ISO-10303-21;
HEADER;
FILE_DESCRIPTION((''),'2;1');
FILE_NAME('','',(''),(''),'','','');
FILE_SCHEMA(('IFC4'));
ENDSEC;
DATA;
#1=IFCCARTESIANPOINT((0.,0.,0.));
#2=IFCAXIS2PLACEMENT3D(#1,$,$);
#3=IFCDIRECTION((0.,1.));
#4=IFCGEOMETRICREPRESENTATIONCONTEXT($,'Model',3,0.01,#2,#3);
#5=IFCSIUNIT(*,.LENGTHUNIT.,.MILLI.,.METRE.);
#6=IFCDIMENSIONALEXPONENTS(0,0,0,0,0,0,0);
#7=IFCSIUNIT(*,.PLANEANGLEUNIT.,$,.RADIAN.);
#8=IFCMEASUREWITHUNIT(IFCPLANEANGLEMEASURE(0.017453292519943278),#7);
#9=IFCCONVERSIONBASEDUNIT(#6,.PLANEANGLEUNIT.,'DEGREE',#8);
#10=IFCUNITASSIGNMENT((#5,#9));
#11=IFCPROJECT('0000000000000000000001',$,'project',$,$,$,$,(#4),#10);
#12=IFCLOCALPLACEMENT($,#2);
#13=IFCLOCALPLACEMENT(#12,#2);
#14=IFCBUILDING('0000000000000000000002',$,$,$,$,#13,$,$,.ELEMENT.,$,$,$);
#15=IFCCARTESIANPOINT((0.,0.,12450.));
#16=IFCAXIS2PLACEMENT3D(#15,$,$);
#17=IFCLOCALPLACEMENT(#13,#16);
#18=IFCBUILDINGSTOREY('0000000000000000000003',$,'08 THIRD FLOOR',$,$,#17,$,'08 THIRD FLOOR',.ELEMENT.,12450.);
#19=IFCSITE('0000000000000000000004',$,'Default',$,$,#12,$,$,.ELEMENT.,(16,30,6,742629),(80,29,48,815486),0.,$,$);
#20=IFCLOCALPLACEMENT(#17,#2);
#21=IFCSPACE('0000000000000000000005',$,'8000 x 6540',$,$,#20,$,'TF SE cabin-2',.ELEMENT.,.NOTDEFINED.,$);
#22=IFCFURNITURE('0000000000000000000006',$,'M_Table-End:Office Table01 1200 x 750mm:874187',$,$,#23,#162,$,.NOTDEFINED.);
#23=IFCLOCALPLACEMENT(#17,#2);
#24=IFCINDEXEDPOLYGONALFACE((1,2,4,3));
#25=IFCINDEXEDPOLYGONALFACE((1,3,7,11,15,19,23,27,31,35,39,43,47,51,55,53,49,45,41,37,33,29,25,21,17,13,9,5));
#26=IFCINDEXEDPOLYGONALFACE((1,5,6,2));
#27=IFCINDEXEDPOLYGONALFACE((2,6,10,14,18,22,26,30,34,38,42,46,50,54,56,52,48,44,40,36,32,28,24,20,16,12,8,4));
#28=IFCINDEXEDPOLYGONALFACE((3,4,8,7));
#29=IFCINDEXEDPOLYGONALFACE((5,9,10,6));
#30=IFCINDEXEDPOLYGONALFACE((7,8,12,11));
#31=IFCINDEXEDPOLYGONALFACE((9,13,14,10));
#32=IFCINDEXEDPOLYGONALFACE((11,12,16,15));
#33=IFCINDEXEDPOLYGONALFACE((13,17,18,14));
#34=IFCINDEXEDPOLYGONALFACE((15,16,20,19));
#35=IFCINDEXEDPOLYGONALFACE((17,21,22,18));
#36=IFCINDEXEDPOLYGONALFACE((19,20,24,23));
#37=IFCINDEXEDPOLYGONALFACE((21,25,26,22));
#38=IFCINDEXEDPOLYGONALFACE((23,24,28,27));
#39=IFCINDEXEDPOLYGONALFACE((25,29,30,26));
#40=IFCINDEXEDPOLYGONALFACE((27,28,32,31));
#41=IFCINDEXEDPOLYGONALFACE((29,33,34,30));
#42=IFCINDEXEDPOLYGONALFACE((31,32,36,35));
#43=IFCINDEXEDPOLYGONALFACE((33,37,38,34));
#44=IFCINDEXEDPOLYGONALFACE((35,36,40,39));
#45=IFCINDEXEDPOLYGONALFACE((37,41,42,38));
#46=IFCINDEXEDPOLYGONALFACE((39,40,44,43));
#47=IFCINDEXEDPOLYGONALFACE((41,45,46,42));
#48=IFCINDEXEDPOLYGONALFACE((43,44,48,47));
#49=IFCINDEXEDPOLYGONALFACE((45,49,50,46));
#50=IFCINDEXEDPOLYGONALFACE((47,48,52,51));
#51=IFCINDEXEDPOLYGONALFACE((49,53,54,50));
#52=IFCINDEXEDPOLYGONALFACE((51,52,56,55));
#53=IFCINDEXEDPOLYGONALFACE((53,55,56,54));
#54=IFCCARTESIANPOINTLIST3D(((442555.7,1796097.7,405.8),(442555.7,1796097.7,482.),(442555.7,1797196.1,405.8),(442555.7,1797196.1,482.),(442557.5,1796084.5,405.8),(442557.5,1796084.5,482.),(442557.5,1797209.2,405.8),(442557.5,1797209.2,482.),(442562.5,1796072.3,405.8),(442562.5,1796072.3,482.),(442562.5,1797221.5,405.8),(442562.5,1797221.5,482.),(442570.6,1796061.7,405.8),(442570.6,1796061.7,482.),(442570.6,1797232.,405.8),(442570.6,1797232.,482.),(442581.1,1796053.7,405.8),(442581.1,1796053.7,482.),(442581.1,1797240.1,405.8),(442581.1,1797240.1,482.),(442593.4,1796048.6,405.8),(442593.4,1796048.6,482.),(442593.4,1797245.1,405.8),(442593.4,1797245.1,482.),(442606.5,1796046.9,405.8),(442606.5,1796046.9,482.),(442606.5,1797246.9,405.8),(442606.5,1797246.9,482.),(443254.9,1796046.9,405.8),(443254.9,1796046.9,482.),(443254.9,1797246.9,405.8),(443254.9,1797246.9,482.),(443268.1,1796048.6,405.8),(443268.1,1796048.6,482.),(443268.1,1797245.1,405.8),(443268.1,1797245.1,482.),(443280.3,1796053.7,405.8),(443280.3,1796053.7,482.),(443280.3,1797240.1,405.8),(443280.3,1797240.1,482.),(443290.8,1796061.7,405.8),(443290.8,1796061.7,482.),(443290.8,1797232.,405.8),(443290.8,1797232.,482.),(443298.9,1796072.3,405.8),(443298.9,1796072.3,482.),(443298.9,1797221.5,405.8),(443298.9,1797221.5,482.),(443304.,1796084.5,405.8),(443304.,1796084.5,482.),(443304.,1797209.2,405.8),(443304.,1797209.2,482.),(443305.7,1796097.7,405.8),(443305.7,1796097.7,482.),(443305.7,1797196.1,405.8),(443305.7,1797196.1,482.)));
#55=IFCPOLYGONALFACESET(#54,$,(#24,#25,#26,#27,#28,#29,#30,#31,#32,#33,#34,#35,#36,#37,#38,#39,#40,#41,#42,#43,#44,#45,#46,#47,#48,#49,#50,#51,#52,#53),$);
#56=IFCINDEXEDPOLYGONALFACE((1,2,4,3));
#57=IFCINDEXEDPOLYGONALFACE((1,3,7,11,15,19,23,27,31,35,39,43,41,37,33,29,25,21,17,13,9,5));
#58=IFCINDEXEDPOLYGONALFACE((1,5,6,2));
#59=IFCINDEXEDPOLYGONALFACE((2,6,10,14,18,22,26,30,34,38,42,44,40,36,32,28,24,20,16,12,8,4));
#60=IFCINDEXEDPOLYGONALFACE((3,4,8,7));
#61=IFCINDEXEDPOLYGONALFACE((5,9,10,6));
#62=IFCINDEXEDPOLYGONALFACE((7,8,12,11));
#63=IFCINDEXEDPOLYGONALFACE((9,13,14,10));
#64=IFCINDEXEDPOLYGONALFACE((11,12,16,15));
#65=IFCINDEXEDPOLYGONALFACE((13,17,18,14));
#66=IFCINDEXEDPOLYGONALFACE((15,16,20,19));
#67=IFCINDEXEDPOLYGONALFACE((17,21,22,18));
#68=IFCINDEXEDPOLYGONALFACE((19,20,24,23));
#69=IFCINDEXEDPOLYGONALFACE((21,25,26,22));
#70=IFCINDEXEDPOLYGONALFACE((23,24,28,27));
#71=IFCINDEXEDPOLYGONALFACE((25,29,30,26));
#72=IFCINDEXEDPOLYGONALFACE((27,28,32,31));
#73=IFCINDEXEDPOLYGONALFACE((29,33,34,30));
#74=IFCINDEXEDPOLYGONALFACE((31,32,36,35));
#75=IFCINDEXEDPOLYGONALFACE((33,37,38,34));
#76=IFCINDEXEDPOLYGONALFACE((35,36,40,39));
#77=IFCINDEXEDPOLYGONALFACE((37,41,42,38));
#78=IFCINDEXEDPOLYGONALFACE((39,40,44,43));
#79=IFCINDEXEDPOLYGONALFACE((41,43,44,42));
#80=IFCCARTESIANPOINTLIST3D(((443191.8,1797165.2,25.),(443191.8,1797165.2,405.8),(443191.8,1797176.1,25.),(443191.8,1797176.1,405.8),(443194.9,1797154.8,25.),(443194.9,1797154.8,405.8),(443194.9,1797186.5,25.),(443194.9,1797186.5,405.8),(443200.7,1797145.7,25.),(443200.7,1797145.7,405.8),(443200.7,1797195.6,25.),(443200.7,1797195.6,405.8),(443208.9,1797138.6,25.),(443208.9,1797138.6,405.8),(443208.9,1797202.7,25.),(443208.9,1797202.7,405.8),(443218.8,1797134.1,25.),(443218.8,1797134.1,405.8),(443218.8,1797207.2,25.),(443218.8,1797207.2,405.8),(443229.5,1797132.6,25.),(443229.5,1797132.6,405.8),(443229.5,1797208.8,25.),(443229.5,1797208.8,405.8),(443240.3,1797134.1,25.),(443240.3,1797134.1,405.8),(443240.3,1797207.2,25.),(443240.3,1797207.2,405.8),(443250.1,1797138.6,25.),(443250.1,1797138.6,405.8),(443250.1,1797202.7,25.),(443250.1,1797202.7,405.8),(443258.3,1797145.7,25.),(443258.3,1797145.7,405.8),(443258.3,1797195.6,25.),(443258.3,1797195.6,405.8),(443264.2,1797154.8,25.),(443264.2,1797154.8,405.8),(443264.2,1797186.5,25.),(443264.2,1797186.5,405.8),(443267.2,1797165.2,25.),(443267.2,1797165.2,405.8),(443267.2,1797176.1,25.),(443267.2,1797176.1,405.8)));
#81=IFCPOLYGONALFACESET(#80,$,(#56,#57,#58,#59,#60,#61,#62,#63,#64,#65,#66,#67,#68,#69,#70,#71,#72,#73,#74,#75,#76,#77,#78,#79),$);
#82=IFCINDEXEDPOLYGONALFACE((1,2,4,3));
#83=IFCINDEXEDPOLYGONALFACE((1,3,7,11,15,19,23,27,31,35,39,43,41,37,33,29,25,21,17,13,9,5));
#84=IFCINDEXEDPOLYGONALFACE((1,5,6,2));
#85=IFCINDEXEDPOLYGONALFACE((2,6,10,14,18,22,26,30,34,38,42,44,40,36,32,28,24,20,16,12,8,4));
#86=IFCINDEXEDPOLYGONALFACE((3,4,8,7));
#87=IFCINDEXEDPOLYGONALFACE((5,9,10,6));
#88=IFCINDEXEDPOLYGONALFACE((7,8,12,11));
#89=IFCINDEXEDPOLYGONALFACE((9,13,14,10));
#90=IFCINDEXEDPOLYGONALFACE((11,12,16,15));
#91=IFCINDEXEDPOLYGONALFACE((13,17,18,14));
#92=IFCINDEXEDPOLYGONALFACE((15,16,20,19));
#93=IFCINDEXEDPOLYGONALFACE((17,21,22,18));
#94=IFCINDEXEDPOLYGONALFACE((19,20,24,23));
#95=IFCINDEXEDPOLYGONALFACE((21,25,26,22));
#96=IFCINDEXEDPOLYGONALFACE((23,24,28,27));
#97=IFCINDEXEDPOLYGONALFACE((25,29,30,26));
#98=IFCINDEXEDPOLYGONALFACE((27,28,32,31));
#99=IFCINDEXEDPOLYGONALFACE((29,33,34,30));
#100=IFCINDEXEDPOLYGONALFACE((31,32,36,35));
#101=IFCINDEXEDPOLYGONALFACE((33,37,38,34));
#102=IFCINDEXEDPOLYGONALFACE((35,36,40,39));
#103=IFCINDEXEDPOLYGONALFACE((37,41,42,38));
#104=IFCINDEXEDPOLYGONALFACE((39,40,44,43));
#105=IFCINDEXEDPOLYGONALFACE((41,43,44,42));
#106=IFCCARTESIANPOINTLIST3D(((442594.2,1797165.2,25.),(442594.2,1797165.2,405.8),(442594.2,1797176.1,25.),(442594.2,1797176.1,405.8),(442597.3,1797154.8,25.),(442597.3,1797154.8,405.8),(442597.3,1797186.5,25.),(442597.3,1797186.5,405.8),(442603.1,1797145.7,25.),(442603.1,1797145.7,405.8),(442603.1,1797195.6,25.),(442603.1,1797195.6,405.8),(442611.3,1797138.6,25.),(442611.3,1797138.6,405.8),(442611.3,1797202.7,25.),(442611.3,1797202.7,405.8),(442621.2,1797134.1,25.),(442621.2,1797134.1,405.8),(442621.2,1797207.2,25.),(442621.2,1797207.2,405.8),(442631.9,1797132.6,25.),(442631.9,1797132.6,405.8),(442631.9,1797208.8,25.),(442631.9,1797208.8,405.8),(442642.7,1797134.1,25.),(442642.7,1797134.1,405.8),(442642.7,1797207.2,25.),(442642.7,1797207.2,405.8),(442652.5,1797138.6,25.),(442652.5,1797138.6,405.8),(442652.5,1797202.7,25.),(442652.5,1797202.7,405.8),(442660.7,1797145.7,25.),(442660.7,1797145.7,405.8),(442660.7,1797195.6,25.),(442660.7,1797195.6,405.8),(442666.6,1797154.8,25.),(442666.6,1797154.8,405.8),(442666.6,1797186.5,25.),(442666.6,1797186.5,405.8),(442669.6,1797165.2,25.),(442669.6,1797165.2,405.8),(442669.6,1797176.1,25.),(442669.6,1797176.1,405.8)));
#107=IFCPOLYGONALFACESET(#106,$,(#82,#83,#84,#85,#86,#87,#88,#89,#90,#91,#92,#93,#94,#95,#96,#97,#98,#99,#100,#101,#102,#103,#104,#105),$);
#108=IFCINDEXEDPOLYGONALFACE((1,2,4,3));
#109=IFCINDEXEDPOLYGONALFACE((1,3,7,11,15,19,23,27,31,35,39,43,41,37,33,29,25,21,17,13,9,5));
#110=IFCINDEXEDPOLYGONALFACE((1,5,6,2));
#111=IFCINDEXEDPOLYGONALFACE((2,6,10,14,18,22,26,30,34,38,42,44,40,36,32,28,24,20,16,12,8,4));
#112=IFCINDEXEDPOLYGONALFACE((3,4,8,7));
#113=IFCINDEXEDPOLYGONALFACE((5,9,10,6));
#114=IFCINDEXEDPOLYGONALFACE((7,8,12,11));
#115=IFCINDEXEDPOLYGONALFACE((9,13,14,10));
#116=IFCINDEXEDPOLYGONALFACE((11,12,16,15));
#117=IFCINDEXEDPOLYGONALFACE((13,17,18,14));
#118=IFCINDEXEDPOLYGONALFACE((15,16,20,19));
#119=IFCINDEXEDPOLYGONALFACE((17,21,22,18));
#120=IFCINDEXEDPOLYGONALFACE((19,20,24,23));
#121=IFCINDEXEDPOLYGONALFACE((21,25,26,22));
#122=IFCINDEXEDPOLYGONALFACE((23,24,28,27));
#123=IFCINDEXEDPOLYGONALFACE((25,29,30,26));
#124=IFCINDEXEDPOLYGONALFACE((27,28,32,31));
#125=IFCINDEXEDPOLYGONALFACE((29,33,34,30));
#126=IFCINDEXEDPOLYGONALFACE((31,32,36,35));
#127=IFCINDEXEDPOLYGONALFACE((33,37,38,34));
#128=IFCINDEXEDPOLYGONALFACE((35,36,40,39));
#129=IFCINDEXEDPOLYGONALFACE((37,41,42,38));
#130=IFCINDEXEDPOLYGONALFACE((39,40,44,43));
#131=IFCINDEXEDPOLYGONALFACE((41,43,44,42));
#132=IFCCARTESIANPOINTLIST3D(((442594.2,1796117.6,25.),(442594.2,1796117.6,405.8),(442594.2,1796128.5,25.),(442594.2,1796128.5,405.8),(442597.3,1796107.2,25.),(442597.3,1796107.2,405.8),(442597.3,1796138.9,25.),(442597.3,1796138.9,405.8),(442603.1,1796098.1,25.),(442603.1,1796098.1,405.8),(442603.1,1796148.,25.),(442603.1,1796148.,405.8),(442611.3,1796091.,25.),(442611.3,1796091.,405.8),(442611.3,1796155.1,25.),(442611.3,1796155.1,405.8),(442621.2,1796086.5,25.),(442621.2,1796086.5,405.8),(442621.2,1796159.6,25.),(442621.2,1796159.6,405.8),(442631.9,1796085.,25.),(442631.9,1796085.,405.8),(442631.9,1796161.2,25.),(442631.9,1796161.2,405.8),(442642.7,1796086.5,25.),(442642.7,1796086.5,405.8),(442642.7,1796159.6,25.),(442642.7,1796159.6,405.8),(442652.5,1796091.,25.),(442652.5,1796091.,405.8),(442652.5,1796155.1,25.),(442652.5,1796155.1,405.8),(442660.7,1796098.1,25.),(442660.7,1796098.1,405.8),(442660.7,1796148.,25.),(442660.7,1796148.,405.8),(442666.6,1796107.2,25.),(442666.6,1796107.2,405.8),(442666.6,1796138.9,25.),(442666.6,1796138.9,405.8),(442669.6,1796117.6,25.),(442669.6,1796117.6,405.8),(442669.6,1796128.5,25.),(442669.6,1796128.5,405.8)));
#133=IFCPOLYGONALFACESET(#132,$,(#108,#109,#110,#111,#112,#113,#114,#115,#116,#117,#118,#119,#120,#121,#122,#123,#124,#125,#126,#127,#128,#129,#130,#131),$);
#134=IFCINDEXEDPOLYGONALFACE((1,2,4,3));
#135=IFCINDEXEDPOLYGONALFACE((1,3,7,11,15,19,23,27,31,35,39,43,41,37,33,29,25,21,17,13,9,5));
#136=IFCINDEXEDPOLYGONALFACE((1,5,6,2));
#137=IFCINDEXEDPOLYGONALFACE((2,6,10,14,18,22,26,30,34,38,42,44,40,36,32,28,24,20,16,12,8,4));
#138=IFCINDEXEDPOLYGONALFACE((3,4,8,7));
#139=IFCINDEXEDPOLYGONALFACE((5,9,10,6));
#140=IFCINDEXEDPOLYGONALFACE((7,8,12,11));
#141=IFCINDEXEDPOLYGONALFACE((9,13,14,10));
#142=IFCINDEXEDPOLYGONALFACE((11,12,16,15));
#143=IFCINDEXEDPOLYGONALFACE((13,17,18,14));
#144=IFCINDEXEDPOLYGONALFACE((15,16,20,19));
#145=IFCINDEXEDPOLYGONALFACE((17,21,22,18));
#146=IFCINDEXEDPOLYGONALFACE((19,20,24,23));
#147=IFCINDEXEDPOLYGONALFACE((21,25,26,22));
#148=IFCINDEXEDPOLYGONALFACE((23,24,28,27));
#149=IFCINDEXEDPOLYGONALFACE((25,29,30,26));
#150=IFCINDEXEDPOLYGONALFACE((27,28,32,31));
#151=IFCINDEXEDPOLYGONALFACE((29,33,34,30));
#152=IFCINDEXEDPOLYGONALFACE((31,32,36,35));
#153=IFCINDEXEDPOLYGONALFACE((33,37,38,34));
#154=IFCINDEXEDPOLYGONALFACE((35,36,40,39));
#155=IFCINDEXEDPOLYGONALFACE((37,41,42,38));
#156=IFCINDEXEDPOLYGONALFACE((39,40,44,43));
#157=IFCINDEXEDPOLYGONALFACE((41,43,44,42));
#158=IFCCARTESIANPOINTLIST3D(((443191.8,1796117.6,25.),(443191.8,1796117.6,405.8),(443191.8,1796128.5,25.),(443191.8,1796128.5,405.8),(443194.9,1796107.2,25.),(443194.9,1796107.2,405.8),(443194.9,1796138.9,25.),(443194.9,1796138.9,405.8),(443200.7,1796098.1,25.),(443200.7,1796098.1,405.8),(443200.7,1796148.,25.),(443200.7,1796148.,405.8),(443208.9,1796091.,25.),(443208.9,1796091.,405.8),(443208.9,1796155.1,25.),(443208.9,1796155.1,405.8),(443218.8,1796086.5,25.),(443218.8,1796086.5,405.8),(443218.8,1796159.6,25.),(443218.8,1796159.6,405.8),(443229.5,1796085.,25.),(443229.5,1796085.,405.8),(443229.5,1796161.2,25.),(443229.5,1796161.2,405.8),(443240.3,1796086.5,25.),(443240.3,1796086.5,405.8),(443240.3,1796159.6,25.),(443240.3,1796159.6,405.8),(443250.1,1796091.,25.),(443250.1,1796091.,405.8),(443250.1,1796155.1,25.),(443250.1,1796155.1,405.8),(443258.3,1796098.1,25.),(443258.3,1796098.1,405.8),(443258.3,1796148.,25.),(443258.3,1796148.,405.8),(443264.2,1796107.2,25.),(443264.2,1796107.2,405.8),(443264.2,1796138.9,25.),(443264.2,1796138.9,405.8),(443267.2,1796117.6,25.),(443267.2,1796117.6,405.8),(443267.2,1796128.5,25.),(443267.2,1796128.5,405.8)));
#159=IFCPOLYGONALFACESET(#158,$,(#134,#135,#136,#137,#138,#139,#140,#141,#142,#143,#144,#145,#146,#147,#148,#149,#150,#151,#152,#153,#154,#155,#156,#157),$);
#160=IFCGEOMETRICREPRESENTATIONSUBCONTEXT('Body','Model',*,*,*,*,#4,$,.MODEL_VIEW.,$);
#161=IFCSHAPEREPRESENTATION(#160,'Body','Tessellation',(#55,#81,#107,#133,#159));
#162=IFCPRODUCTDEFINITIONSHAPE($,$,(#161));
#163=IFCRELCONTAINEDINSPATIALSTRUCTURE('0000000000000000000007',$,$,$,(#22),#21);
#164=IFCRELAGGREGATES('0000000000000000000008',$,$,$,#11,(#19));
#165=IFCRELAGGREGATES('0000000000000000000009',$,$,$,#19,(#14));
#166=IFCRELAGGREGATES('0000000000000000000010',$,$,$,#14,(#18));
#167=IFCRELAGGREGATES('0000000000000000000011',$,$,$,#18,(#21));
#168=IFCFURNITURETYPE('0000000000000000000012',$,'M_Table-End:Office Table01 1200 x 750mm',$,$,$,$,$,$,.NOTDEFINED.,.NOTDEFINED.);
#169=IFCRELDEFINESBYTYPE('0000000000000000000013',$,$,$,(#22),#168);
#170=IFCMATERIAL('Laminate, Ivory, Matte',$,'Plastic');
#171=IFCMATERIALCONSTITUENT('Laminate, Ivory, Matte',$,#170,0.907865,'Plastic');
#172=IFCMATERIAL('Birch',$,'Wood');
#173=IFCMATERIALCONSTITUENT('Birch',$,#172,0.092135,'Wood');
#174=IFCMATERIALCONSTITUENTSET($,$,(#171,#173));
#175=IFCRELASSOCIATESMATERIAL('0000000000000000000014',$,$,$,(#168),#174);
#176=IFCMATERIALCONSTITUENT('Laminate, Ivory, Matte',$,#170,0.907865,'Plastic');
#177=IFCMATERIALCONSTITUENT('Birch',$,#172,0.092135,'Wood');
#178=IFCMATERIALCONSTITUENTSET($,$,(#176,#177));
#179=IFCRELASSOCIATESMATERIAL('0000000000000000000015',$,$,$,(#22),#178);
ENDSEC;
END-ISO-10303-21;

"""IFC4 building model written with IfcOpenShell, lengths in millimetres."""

from ifc_helpers import new_model, entity, si_unit, converted_unit, direction, frame, origin, place, context, subcontext, project, spatial, line, arc, indexed_curve, outline, extrude, source, transform, mapped, material, constituent, constituent_set, type_object, type_shapes, element, save


model = new_model("IFC4")

# Units and contexts
model_context = context("Model", 3, precision=0.01, world=origin(), true_north=direction((0.0, 1.0)))
body_context = subcontext(model_context, "Body", "Model", "MODEL_VIEW")
ifc_project = project(units=[si_unit("LENGTHUNIT", "METRE", prefix="MILLI"), converted_unit("PLANEANGLEUNIT", "DEGREE", entity("IfcPlaneAngleMeasure", 0.017453292519943278), si_unit("PLANEANGLEUNIT", "RADIAN"), dimensions=[0, 0, 0, 0, 0, 0, 0])], contexts=[model_context])

# Site, building, storey
site_placement = place(None, origin())
site = spatial("IfcSite", under=ifc_project, at=site_placement, Name="Default", CompositionType="ELEMENT", RefLatitude=(16, 30, 6, 742629), RefLongitude=(80, 29, 48, 815486), RefElevation=0.0)
building_placement = place(site_placement, origin())
building = spatial("IfcBuilding", under=site, at=building_placement, CompositionType="ELEMENT")
storey_placement = place(building_placement, frame((0.0, 0.0, 12450.0)))
storey = spatial("IfcBuildingStorey", under=building, at=storey_placement, Name="08 THIRD FLOOR", LongName="08 THIRD FLOOR", CompositionType="ELEMENT", Elevation=12450.0)

# Shared definitions
space_1_placement = place(storey_placement, origin())
space_1 = spatial("IfcSpace", under=storey, at=space_1_placement, Name="8000 x 6540", LongName="TF SE cabin-2", CompositionType="ELEMENT", PredefinedType="NOTDEFINED")

# Furniture
ifc_material_1 = material(Name="Laminate, Ivory, Matte", Category="Plastic")
ifc_constituent_1 = constituent(ifc_material_1, Name="Laminate, Ivory, Matte", Category="Plastic", fraction=0.907865)
ifc_material_2 = material(Name="Birch", Category="Wood")
ifc_constituent_2 = constituent(ifc_material_2, Name="Birch", Category="Wood", fraction=0.092135)
ifc_constituent_set_1 = constituent_set(constituents=[ifc_constituent_1, ifc_constituent_2])
ifc_constituent_3 = constituent(ifc_material_1, Name="Laminate, Ivory, Matte", Category="Plastic", fraction=0.907865)
ifc_constituent_4 = constituent(ifc_material_2, Name="Birch", Category="Wood", fraction=0.092135)
ifc_constituent_set_2 = constituent_set(constituents=[ifc_constituent_3, ifc_constituent_4])
furniture_type_1 = type_object("IfcFurnitureType", Name="M_Table-End:Office Table01 1200 x 750mm", AssemblyPlace="NOTDEFINED", PredefinedType="NOTDEFINED", material=ifc_constituent_set_2)
shared_shape_1 = source(origin(), body_context, "Body", "SweptSolid", [
    extrude(outline(indexed_curve([(549.2, -375.0), (585.1, -360.1), (600.0, -324.2), (600.0, 324.2), (585.1, 360.1), (549.2, 375.0), (-549.2, 375.0), (-585.1, 360.1), (-600.0, 324.2), (-600.0, -324.2), (-585.1, -360.1), (-549.2, -375.0)], segments=[arc(1, 2, 3), line(3, 4), arc(4, 5, 6), line(6, 7), arc(7, 8, 9), line(9, 10), arc(10, 11, 12), line(12, 1)], self_intersect=False)), frame((603.7, 152.4, 405.8)), (0.0, 0.0, 1.0), 76.2),
    extrude(outline(indexed_curve([(-38.1, 0.0), (0.0, -38.1), (38.1, 0.0), (0.0, 38.1)], segments=[arc(1, 2, 3), arc(3, 4, 1)], self_intersect=False)), frame((1127.5, -146.4, 25.0)), (0.0, 0.0, 1.0), 380.8),
    extrude(outline(indexed_curve([(-38.1, 0.0), (0.0, -38.1), (38.1, 0.0), (0.0, 38.1)], segments=[arc(1, 2, 3), arc(3, 4, 1)], self_intersect=False)), frame((1127.5, 451.2, 25.0)), (0.0, 0.0, 1.0), 380.8),
    extrude(outline(indexed_curve([(-38.1, 0.0), (0.0, -38.1), (38.1, 0.0), (0.0, 38.1)], segments=[arc(1, 2, 3), arc(3, 4, 1)], self_intersect=False)), frame((79.9, 451.2, 25.0)), (0.0, 0.0, 1.0), 380.8),
    extrude(outline(indexed_curve([(-38.1, 0.0), (0.0, -38.1), (38.1, 0.0), (0.0, 38.1)], segments=[arc(1, 2, 3), arc(3, 4, 1)], self_intersect=False)), frame((79.9, -146.4, 25.0)), (0.0, 0.0, 1.0), 380.8),
])
type_shapes(furniture_type_1, [shared_shape_1])
furniture_1_placement = place(space_1_placement, frame((443083.1, 1796043.1, 0.0), z_axis=(0.0, 0.0, 1.0), x_axis=(0.0, 1.0, 0.0)))
element("IfcFurniture", 1, at=furniture_1_placement, inside=space_1, type_object=furniture_type_1, material=ifc_constituent_set_1, Name="M_Table-End:Office Table01 1200 x 750mm:874187", PredefinedType="NOTDEFINED", context=body_context, shape_type="MappedRepresentation", body=[
    mapped(shared_shape_1, transform((0.0, 0.0, 0.0), scale=1.0)),
])

save(model, "model.ifc")
